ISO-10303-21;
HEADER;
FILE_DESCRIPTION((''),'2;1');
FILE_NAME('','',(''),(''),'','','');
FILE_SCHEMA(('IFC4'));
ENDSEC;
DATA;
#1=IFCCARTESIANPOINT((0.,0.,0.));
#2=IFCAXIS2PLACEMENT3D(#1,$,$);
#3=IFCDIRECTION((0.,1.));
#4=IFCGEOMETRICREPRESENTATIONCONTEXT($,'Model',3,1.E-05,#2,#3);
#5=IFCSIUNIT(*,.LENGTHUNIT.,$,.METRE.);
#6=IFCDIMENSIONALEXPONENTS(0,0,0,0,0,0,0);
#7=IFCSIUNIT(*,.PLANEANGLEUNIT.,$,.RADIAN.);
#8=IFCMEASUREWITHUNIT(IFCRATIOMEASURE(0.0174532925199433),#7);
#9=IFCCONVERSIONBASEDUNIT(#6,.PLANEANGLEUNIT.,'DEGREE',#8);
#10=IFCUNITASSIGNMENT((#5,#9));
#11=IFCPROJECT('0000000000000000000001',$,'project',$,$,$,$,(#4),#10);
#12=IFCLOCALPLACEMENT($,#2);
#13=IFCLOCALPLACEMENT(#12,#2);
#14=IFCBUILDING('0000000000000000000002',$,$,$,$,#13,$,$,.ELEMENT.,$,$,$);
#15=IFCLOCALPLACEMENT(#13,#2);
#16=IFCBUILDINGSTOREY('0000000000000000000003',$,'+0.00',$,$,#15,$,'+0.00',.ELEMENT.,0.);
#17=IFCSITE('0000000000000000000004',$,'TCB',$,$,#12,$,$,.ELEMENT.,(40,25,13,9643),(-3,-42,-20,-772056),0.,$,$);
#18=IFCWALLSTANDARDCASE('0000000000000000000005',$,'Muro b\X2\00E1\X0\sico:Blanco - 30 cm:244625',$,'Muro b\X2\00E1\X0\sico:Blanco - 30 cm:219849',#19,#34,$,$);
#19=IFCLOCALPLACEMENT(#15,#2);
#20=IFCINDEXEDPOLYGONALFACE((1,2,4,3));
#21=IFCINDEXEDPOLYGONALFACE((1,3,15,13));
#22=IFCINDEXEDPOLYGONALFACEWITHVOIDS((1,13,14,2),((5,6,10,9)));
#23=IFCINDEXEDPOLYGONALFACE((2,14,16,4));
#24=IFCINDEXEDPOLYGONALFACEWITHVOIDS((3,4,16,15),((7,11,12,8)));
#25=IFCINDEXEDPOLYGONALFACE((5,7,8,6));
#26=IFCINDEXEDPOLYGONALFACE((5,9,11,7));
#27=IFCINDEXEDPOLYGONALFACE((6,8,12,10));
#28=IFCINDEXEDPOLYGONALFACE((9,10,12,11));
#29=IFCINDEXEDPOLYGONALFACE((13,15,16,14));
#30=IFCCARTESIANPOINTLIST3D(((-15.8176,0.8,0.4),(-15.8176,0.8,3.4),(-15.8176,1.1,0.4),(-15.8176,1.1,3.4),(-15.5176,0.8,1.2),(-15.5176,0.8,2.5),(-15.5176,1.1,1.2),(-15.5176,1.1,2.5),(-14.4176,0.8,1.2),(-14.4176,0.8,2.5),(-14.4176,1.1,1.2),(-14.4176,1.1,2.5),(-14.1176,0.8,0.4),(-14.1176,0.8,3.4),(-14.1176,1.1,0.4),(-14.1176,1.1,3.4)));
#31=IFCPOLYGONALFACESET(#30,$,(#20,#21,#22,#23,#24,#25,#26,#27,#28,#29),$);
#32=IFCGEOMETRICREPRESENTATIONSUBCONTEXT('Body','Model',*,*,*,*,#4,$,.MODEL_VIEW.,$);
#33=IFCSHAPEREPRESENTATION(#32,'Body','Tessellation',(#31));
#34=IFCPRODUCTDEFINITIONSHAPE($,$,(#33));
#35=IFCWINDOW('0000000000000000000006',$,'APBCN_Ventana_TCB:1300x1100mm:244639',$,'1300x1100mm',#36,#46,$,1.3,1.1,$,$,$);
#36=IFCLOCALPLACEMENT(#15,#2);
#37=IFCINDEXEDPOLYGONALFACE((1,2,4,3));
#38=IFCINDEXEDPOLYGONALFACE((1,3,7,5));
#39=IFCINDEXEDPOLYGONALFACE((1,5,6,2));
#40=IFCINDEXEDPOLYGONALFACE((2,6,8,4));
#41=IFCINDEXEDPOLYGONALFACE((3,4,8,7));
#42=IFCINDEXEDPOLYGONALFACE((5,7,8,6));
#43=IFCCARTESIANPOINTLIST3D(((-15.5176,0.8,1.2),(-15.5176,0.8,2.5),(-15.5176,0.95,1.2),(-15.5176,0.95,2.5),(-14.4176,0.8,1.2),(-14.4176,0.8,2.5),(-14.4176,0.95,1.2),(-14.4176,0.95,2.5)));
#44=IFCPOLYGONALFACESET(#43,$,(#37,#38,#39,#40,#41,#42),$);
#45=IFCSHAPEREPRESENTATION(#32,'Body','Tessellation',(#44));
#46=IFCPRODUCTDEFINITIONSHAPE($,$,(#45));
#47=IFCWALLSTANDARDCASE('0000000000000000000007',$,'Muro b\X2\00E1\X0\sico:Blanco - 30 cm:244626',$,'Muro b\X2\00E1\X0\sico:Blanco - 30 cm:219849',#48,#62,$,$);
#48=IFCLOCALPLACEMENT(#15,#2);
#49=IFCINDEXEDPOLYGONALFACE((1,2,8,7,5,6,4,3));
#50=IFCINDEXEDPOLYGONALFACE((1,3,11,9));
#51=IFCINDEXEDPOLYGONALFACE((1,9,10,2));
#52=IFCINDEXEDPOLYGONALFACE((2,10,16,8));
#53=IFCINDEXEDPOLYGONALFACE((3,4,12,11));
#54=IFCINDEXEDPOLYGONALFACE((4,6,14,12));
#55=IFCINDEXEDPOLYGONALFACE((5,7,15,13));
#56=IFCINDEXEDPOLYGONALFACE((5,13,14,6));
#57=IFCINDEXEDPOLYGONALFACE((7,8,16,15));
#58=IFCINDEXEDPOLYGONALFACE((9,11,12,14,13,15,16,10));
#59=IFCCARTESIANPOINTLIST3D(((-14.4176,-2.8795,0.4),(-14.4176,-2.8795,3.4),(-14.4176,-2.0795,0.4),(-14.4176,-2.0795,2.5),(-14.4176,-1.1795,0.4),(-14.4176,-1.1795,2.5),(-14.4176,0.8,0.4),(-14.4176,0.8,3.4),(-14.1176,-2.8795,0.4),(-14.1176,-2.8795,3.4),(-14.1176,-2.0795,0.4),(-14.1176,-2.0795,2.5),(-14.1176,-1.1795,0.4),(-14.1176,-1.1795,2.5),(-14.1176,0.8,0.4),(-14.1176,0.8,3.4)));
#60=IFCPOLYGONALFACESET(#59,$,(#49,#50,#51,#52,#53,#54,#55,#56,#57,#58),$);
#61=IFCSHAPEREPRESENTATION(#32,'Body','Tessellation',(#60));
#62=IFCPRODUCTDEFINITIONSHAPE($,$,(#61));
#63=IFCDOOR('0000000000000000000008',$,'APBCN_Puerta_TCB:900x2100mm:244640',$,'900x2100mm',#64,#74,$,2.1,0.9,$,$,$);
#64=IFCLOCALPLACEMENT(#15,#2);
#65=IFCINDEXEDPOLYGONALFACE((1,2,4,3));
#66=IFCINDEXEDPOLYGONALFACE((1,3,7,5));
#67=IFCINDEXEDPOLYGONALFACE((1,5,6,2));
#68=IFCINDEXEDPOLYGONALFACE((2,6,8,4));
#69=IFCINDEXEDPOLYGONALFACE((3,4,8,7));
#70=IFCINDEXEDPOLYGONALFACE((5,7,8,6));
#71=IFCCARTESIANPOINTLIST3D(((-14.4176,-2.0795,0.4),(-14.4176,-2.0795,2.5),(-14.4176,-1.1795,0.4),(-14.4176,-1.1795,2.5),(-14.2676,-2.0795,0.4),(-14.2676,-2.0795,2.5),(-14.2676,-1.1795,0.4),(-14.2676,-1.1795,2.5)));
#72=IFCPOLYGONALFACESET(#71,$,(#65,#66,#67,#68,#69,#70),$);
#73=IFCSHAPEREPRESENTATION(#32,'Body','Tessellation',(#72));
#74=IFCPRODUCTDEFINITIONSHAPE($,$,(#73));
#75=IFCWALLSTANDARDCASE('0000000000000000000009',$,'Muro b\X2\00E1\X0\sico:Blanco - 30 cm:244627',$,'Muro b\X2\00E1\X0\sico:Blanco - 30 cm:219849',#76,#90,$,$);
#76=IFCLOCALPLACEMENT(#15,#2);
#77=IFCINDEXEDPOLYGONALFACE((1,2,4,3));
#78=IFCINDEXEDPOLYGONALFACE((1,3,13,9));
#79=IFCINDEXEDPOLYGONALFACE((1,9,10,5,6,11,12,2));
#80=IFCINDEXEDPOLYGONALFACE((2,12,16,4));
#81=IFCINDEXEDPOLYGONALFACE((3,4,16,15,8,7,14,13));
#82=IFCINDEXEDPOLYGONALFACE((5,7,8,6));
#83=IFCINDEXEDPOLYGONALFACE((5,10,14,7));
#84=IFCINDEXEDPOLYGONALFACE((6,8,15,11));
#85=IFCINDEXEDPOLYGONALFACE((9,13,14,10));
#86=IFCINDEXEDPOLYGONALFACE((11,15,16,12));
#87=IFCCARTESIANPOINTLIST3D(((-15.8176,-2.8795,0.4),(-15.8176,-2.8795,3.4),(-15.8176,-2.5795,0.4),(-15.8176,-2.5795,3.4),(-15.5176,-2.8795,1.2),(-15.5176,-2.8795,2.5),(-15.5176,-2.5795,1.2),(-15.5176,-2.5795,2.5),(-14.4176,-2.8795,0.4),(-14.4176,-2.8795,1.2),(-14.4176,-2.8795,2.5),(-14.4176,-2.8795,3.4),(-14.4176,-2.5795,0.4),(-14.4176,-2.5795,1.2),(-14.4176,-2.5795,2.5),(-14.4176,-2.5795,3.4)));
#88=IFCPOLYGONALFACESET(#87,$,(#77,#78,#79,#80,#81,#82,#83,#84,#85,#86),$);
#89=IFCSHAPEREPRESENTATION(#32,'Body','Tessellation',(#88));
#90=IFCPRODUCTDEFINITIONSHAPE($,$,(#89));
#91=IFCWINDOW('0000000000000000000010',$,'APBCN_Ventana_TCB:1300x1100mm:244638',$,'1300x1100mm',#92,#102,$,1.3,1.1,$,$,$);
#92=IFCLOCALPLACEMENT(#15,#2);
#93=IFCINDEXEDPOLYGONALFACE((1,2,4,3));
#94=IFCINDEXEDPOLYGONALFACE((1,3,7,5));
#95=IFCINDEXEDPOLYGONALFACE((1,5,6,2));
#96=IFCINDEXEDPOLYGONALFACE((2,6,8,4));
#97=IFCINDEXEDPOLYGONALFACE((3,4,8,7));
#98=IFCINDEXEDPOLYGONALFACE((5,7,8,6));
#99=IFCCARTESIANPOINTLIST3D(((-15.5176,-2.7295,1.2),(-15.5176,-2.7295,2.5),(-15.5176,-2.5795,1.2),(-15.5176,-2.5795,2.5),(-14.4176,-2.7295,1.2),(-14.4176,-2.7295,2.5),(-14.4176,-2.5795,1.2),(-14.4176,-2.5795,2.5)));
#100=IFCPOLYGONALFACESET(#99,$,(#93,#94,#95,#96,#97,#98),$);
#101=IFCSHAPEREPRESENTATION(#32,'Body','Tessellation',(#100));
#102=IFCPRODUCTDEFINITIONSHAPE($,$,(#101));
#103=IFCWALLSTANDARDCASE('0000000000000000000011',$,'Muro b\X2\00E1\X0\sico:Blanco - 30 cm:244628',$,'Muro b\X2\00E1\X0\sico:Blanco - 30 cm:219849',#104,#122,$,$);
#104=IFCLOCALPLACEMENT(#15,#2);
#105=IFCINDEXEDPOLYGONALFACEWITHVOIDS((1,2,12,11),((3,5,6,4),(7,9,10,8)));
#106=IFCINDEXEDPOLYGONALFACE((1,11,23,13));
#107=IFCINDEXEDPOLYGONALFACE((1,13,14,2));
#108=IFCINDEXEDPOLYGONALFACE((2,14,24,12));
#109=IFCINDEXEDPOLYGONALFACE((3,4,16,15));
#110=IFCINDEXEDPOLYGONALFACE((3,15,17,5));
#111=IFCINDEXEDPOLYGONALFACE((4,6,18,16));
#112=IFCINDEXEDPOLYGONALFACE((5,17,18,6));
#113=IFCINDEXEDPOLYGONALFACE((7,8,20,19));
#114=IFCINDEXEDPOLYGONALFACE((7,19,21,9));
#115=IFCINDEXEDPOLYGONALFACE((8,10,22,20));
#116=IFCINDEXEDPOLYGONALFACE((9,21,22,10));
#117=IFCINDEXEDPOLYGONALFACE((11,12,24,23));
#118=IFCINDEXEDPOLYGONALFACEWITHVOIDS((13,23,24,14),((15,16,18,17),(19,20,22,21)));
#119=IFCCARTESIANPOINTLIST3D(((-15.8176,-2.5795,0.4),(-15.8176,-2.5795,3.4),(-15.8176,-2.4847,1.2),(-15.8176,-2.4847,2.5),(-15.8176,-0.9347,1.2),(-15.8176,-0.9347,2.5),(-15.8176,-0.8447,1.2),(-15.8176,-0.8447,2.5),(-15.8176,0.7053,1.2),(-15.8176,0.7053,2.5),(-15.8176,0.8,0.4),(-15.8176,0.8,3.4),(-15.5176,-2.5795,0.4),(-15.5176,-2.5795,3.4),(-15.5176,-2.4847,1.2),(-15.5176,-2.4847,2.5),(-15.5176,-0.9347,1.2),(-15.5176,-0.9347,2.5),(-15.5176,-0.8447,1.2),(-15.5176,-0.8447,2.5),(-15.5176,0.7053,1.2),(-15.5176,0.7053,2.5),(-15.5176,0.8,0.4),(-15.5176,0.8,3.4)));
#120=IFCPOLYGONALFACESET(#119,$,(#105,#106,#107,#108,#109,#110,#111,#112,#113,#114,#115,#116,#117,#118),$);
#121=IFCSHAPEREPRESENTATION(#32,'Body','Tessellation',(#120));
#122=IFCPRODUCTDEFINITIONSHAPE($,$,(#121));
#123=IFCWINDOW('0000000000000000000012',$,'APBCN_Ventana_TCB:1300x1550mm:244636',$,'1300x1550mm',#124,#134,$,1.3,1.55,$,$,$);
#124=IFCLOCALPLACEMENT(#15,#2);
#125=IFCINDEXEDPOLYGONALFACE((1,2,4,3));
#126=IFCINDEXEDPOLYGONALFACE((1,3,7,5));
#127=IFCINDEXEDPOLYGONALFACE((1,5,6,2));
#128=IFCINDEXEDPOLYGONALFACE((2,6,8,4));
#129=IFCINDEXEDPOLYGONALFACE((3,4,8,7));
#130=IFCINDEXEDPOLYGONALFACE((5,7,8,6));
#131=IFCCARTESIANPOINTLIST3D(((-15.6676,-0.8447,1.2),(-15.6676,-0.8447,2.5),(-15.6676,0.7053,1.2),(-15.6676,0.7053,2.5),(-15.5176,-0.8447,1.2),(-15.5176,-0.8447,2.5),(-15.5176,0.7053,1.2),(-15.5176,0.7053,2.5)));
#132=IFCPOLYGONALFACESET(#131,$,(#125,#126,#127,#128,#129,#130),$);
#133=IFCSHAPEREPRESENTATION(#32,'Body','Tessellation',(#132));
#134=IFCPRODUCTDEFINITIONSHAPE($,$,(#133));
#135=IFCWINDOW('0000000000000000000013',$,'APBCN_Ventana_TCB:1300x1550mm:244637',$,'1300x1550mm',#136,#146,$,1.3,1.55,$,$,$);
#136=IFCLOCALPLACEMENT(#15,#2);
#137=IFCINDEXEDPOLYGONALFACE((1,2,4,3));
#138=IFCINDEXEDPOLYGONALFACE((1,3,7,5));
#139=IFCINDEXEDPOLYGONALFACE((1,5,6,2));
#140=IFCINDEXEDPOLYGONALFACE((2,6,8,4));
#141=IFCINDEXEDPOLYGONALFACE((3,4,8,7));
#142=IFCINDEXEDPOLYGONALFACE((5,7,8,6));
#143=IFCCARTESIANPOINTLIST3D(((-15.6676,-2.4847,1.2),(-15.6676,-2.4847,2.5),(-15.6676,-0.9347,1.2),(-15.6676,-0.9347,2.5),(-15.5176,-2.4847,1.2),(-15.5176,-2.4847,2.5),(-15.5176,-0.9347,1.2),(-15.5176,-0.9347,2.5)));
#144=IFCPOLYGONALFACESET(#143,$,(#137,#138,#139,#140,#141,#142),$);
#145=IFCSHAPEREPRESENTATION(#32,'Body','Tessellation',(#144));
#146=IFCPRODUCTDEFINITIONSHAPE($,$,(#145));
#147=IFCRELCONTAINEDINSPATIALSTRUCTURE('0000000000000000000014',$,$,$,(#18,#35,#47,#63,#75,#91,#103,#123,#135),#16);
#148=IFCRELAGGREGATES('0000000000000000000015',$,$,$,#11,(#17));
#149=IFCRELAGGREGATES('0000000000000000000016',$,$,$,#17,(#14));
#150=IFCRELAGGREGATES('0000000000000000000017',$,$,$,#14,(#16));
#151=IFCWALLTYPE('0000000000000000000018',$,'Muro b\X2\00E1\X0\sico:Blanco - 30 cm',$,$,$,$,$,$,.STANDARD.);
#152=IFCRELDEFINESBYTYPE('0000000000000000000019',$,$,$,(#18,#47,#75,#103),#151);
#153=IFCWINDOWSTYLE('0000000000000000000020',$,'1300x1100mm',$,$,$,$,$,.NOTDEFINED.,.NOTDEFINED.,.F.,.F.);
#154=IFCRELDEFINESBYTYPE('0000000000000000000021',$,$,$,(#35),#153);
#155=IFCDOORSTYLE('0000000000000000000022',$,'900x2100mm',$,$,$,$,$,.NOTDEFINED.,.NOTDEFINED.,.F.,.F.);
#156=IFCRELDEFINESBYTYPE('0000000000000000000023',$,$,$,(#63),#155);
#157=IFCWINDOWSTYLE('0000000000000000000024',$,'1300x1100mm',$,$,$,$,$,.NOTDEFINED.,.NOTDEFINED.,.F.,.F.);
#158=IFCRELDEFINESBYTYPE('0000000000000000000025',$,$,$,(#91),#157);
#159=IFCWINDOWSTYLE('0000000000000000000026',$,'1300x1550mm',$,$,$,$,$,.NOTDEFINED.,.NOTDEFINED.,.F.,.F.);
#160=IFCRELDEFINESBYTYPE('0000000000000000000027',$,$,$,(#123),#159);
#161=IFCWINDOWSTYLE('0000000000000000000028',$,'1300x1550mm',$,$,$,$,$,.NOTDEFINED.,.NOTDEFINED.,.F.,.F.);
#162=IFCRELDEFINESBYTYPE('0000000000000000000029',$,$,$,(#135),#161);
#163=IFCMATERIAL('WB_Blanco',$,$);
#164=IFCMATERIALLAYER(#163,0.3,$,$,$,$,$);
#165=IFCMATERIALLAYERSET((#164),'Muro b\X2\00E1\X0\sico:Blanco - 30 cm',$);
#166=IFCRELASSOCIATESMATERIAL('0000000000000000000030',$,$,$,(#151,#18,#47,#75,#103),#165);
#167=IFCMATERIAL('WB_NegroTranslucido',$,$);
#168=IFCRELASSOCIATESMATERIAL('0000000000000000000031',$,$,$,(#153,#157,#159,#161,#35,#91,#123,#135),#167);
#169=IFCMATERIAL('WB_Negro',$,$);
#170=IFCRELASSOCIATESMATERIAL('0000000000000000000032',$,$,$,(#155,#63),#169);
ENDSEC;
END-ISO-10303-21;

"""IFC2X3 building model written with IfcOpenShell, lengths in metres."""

from ifc_helpers import new_model, entity, si_unit, converted_unit, direction, frame, frame_2d, origin, origin_2d_with_axis, place, context, subcontext, project, spatial, rectangle, extrude, source, transform, mapped, material, layer, layer_set, layer_usage, type_object, type_shapes, element, fill, save


model = new_model("IFC2X3")

# Units and contexts
model_context = context("Model", 3, precision=1e-05, world=origin(), true_north=direction((0.0, 1.0)))
body_context = subcontext(model_context, "Body", "Model", "MODEL_VIEW")
ifc_project = project(units=[si_unit("LENGTHUNIT", "METRE"), converted_unit("PLANEANGLEUNIT", "DEGREE", entity("IfcRatioMeasure", 0.0174532925199433), si_unit("PLANEANGLEUNIT", "RADIAN"), dimensions=[0, 0, 0, 0, 0, 0, 0])], contexts=[model_context])

# Site, building, storey
site_placement = place(None, origin())
site = spatial("IfcSite", under=ifc_project, at=site_placement, Name="TCB", CompositionType="ELEMENT", RefLatitude=(40, 25, 13, 9643), RefLongitude=(-3, -42, -20, -772056), RefElevation=0.0)
building_placement = place(site_placement, origin())
building = spatial("IfcBuilding", under=site, at=building_placement, CompositionType="ELEMENT")
storey_placement = place(building_placement, origin())
storey = spatial("IfcBuildingStorey", under=building, at=storey_placement, Name="+0.00", LongName="+0.00", CompositionType="ELEMENT", Elevation=0.0)

# Shared definitions
ifc_material_1 = material(Name="WB_Blanco")
ifc_layer = layer(ifc_material_1, 0.3)
ifc_layer_set = layer_set([ifc_layer], Name="Muro básico:Blanco - 30 cm")
wall_type = type_object("IfcWallType", Name="Muro básico:Blanco - 30 cm", PredefinedType="STANDARD", material=ifc_layer_set)
ifc_material_2 = material(Name="WB_NegroTranslucido")
window_style_1 = type_object("IfcWindowStyle", Name="1300x1100mm", ConstructionType="NOTDEFINED", OperationType="NOTDEFINED", ParameterTakesPrecedence=False, Sizeable=False, material=ifc_material_2)
shared_shape_1 = source(origin(), body_context, "Body", "SweptSolid", [
    extrude(rectangle(XDim=0.15, YDim=1.1, at=frame_2d((0.0, 0.0), x_axis=(1.0, 0.0))), frame((0.55, 0.075, 0.0), z_axis=(0.0, 0.0, 1.0), x_axis=(0.0, 1.0, 0.0)), (0.0, 0.0, 1.0), 1.3),
])
type_shapes(window_style_1, [shared_shape_1])

# Shared definitions
ifc_material_3 = material(Name="WB_Negro")
door_style = type_object("IfcDoorStyle", Name="900x2100mm", ConstructionType="NOTDEFINED", OperationType="NOTDEFINED", ParameterTakesPrecedence=False, Sizeable=False, material=ifc_material_3)
shared_shape_2 = source(origin(), body_context, "Body", "SweptSolid", [
    extrude(rectangle(XDim=0.15, YDim=0.9, at=frame_2d((0.0, 0.0), x_axis=(1.0, 0.0))), frame((0.45, 0.075, 0.0), z_axis=(0.0, 0.0, 1.0), x_axis=(0.0, 1.0, 0.0)), (0.0, 0.0, 1.0), 2.1),
])
type_shapes(door_style, [shared_shape_2])

# Shared definitions
window_style_2 = type_object("IfcWindowStyle", Name="1300x1100mm", ConstructionType="NOTDEFINED", OperationType="NOTDEFINED", ParameterTakesPrecedence=False, Sizeable=False, material=ifc_material_2)
shared_shape_3 = source(origin(), body_context, "Body", "SweptSolid", [
    extrude(rectangle(XDim=1.1, YDim=0.15, at=origin_2d_with_axis()), frame((0.55, 0.075, 0.0)), (0.0, 0.0, 1.0), 1.3),
])
type_shapes(window_style_2, [shared_shape_3])

# Shared definitions
window_style_3 = type_object("IfcWindowStyle", Name="1300x1550mm", ConstructionType="NOTDEFINED", OperationType="NOTDEFINED", ParameterTakesPrecedence=False, Sizeable=False, material=ifc_material_2)
shared_shape_4 = source(origin(), body_context, "Body", "SweptSolid", [
    extrude(rectangle(XDim=1.55, YDim=0.15, at=origin_2d_with_axis()), frame((0.775, 0.075, 0.0)), (0.0, 0.0, 1.0), 1.3),
])
type_shapes(window_style_3, [shared_shape_4])
window_style_4 = type_object("IfcWindowStyle", Name="1300x1550mm", ConstructionType="NOTDEFINED", OperationType="NOTDEFINED", ParameterTakesPrecedence=False, Sizeable=False, material=ifc_material_2)
shared_shape_5 = source(origin(), body_context, "Body", "SweptSolid", [
    extrude(rectangle(XDim=0.15, YDim=1.55, at=origin_2d_with_axis()), frame((0.775, 0.075, 0.0), z_axis=(0.0, 0.0, 1.0), x_axis=(0.0, 1.0, 0.0)), (0.0, 0.0, 1.0), 1.3),
])
type_shapes(window_style_4, [shared_shape_5])

# Wall, opening, window
ifc_layer_usage_1 = layer_usage(ifc_layer_set, "AXIS2", "NEGATIVE", 0.15)
wall_1_placement = place(storey_placement, frame((-15.8176, 0.95, 0.4)))
wall_1 = element("IfcWallStandardCase", 1, at=wall_1_placement, inside=storey, type_object=wall_type, material=ifc_layer_usage_1, Name="Muro básico:Blanco - 30 cm:244625", ObjectType="Muro básico:Blanco - 30 cm:219849", context=body_context, shape_type="SweptSolid", body=[
    extrude(rectangle(XDim=1.7, YDim=0.3, at=frame_2d((0.85, 0.0), x_axis=(-1.0, 0.0))), origin(), (0.0, 0.0, 1.0), 3.0),
])
opening_1_placement = place(wall_1_placement, frame((0.3, -0.15, 0.8)))
opening_1 = element("IfcOpeningElement", 2, at=opening_1_placement, cuts=wall_1, ObjectType="Opening", context=body_context, shape_type="SweptSolid", body=[
    extrude(rectangle(XDim=1.3, YDim=1.1, at=frame_2d((0.65, 0.55), x_axis=(1.0, 0.0))), frame((0.0, 0.0, 0.0), z_axis=(0.0, 1.0, 0.0), x_axis=(0.0, 0.0, 1.0)), (0.0, 0.0, 1.0), 0.3),
])
window_1_placement = place(opening_1_placement, origin())
window_1 = element("IfcWindow", 3, at=window_1_placement, inside=storey, type_object=window_style_1, material=ifc_material_2, Name="APBCN_Ventana_TCB:1300x1100mm:244639", ObjectType="1300x1100mm", OverallHeight=1.3, OverallWidth=1.1, context=body_context, shape_type="MappedRepresentation", body=[
    mapped(shared_shape_1, transform((0.0, 0.0, 0.0), scale=1.0)),
])
fill(opening_1, window_1)

# Wall, opening, door
ifc_layer_usage_2 = layer_usage(ifc_layer_set, "AXIS2", "NEGATIVE", 0.15)
wall_2_placement = place(storey_placement, frame((-14.2676, 0.8, 0.4), z_axis=(0.0, 0.0, 1.0), x_axis=(0.0, -1.0, 0.0)))
wall_2 = element("IfcWallStandardCase", 4, at=wall_2_placement, inside=storey, type_object=wall_type, material=ifc_layer_usage_2, Name="Muro básico:Blanco - 30 cm:244626", ObjectType="Muro básico:Blanco - 30 cm:219849", context=body_context, shape_type="SweptSolid", body=[
    extrude(rectangle(XDim=3.6795, YDim=0.3, at=frame_2d((1.8397, 0.0), x_axis=(-1.0, 0.0))), origin(), (0.0, 0.0, 1.0), 3.0),
])
opening_2_placement = place(wall_2_placement, frame((1.9795, -0.15, 0.0)))
opening_2 = element("IfcOpeningElement", 5, at=opening_2_placement, cuts=wall_2, ObjectType="Opening", context=body_context, shape_type="SweptSolid", body=[
    extrude(rectangle(XDim=2.1, YDim=0.9, at=frame_2d((1.05, 0.45), x_axis=(1.0, 0.0))), frame((0.0, 0.0, 0.0), z_axis=(0.0, 1.0, 0.0), x_axis=(0.0, 0.0, 1.0)), (0.0, 0.0, 1.0), 0.3),
])
door_1_placement = place(opening_2_placement, origin())
door_1 = element("IfcDoor", 6, at=door_1_placement, inside=storey, type_object=door_style, material=ifc_material_3, Name="APBCN_Puerta_TCB:900x2100mm:244640", ObjectType="900x2100mm", OverallHeight=2.1, OverallWidth=0.9, context=body_context, shape_type="MappedRepresentation", body=[
    mapped(shared_shape_2, transform((0.0, 0.0, 0.0), scale=1.0)),
])
fill(opening_2, door_1)

# Wall, opening, window
ifc_layer_usage_3 = layer_usage(ifc_layer_set, "AXIS2", "NEGATIVE", 0.15)
wall_3_placement = place(storey_placement, frame((-14.4176, -2.7295, 0.4), z_axis=(0.0, 0.0, 1.0), x_axis=(-1.0, 0.0, 0.0)))
wall_3 = element("IfcWallStandardCase", 7, at=wall_3_placement, inside=storey, type_object=wall_type, material=ifc_layer_usage_3, Name="Muro básico:Blanco - 30 cm:244627", ObjectType="Muro básico:Blanco - 30 cm:219849", context=body_context, shape_type="SweptSolid", body=[
    extrude(rectangle(XDim=1.4, YDim=0.3, at=frame_2d((0.7, 0.0), x_axis=(-1.0, 0.0))), origin(), (0.0, 0.0, 1.0), 3.0),
])
opening_3_placement = place(wall_3_placement, frame((0.0, -0.15, 0.8)))
opening_3 = element("IfcOpeningElement", 8, at=opening_3_placement, cuts=wall_3, ObjectType="Opening", context=body_context, shape_type="SweptSolid", body=[
    extrude(rectangle(XDim=1.3, YDim=1.1, at=frame_2d((0.65, 0.55), x_axis=(1.0, 0.0))), frame((0.0, 0.0, 0.0), z_axis=(0.0, 1.0, 0.0), x_axis=(0.0, 0.0, 1.0)), (0.0, 0.0, 1.0), 0.3),
])
window_2_placement = place(opening_3_placement, origin())
window_2 = element("IfcWindow", 9, at=window_2_placement, inside=storey, type_object=window_style_2, material=ifc_material_2, Name="APBCN_Ventana_TCB:1300x1100mm:244638", ObjectType="1300x1100mm", OverallHeight=1.3, OverallWidth=1.1, context=body_context, shape_type="MappedRepresentation", body=[
    mapped(shared_shape_3, transform((0.0, 0.0, 0.0), scale=1.0)),
])
fill(opening_3, window_2)

# Wall, openings, windows
ifc_layer_usage_4 = layer_usage(ifc_layer_set, "AXIS2", "NEGATIVE", 0.15)
wall_4_placement = place(storey_placement, frame((-15.6676, -2.5795, 0.4), z_axis=(0.0, 0.0, 1.0), x_axis=(0.0, 1.0, 0.0)))
wall_4 = element("IfcWallStandardCase", 10, at=wall_4_placement, inside=storey, type_object=wall_type, material=ifc_layer_usage_4, Name="Muro básico:Blanco - 30 cm:244628", ObjectType="Muro básico:Blanco - 30 cm:219849", context=body_context, shape_type="SweptSolid", body=[
    extrude(rectangle(XDim=3.3795, YDim=0.3, at=frame_2d((1.6897, 0.0), x_axis=(-1.0, 0.0))), origin(), (0.0, 0.0, 1.0), 3.0),
])
opening_4_placement = place(wall_4_placement, frame((1.7347, -0.15, 0.8)))
opening_4 = element("IfcOpeningElement", 11, at=opening_4_placement, cuts=wall_4, ObjectType="Opening", context=body_context, shape_type="SweptSolid", body=[
    extrude(rectangle(XDim=1.3, YDim=1.55, at=frame_2d((0.65, 0.775), x_axis=(1.0, 0.0))), frame((0.0, 0.0, 0.0), z_axis=(0.0, 1.0, 0.0), x_axis=(0.0, 0.0, 1.0)), (0.0, 0.0, 1.0), 0.3),
])
opening_5_placement = place(wall_4_placement, frame((0.0947, -0.15, 0.8)))
opening_5 = element("IfcOpeningElement", 12, at=opening_5_placement, cuts=wall_4, ObjectType="Opening", context=body_context, shape_type="SweptSolid", body=[
    extrude(rectangle(XDim=1.3, YDim=1.55, at=frame_2d((0.65, 0.775), x_axis=(1.0, 0.0))), frame((0.0, 0.0, 0.0), z_axis=(0.0, 1.0, 0.0), x_axis=(0.0, 0.0, 1.0)), (0.0, 0.0, 1.0), 0.3),
])
window_3_placement = place(opening_4_placement, origin())
window_3 = element("IfcWindow", 13, at=window_3_placement, inside=storey, type_object=window_style_3, material=ifc_material_2, Name="APBCN_Ventana_TCB:1300x1550mm:244636", ObjectType="1300x1550mm", OverallHeight=1.3, OverallWidth=1.55, context=body_context, shape_type="MappedRepresentation", body=[
    mapped(shared_shape_4, transform((0.0, 0.0, 0.0), scale=1.0)),
])
fill(opening_4, window_3)
window_4_placement = place(opening_5_placement, origin())
window_4 = element("IfcWindow", 14, at=window_4_placement, inside=storey, type_object=window_style_4, material=ifc_material_2, Name="APBCN_Ventana_TCB:1300x1550mm:244637", ObjectType="1300x1550mm", OverallHeight=1.3, OverallWidth=1.55, context=body_context, shape_type="MappedRepresentation", body=[
    mapped(shared_shape_5, transform((0.0, 0.0, 0.0), scale=1.0)),
])
fill(opening_5, window_4)

save(model, "model.ifc")
